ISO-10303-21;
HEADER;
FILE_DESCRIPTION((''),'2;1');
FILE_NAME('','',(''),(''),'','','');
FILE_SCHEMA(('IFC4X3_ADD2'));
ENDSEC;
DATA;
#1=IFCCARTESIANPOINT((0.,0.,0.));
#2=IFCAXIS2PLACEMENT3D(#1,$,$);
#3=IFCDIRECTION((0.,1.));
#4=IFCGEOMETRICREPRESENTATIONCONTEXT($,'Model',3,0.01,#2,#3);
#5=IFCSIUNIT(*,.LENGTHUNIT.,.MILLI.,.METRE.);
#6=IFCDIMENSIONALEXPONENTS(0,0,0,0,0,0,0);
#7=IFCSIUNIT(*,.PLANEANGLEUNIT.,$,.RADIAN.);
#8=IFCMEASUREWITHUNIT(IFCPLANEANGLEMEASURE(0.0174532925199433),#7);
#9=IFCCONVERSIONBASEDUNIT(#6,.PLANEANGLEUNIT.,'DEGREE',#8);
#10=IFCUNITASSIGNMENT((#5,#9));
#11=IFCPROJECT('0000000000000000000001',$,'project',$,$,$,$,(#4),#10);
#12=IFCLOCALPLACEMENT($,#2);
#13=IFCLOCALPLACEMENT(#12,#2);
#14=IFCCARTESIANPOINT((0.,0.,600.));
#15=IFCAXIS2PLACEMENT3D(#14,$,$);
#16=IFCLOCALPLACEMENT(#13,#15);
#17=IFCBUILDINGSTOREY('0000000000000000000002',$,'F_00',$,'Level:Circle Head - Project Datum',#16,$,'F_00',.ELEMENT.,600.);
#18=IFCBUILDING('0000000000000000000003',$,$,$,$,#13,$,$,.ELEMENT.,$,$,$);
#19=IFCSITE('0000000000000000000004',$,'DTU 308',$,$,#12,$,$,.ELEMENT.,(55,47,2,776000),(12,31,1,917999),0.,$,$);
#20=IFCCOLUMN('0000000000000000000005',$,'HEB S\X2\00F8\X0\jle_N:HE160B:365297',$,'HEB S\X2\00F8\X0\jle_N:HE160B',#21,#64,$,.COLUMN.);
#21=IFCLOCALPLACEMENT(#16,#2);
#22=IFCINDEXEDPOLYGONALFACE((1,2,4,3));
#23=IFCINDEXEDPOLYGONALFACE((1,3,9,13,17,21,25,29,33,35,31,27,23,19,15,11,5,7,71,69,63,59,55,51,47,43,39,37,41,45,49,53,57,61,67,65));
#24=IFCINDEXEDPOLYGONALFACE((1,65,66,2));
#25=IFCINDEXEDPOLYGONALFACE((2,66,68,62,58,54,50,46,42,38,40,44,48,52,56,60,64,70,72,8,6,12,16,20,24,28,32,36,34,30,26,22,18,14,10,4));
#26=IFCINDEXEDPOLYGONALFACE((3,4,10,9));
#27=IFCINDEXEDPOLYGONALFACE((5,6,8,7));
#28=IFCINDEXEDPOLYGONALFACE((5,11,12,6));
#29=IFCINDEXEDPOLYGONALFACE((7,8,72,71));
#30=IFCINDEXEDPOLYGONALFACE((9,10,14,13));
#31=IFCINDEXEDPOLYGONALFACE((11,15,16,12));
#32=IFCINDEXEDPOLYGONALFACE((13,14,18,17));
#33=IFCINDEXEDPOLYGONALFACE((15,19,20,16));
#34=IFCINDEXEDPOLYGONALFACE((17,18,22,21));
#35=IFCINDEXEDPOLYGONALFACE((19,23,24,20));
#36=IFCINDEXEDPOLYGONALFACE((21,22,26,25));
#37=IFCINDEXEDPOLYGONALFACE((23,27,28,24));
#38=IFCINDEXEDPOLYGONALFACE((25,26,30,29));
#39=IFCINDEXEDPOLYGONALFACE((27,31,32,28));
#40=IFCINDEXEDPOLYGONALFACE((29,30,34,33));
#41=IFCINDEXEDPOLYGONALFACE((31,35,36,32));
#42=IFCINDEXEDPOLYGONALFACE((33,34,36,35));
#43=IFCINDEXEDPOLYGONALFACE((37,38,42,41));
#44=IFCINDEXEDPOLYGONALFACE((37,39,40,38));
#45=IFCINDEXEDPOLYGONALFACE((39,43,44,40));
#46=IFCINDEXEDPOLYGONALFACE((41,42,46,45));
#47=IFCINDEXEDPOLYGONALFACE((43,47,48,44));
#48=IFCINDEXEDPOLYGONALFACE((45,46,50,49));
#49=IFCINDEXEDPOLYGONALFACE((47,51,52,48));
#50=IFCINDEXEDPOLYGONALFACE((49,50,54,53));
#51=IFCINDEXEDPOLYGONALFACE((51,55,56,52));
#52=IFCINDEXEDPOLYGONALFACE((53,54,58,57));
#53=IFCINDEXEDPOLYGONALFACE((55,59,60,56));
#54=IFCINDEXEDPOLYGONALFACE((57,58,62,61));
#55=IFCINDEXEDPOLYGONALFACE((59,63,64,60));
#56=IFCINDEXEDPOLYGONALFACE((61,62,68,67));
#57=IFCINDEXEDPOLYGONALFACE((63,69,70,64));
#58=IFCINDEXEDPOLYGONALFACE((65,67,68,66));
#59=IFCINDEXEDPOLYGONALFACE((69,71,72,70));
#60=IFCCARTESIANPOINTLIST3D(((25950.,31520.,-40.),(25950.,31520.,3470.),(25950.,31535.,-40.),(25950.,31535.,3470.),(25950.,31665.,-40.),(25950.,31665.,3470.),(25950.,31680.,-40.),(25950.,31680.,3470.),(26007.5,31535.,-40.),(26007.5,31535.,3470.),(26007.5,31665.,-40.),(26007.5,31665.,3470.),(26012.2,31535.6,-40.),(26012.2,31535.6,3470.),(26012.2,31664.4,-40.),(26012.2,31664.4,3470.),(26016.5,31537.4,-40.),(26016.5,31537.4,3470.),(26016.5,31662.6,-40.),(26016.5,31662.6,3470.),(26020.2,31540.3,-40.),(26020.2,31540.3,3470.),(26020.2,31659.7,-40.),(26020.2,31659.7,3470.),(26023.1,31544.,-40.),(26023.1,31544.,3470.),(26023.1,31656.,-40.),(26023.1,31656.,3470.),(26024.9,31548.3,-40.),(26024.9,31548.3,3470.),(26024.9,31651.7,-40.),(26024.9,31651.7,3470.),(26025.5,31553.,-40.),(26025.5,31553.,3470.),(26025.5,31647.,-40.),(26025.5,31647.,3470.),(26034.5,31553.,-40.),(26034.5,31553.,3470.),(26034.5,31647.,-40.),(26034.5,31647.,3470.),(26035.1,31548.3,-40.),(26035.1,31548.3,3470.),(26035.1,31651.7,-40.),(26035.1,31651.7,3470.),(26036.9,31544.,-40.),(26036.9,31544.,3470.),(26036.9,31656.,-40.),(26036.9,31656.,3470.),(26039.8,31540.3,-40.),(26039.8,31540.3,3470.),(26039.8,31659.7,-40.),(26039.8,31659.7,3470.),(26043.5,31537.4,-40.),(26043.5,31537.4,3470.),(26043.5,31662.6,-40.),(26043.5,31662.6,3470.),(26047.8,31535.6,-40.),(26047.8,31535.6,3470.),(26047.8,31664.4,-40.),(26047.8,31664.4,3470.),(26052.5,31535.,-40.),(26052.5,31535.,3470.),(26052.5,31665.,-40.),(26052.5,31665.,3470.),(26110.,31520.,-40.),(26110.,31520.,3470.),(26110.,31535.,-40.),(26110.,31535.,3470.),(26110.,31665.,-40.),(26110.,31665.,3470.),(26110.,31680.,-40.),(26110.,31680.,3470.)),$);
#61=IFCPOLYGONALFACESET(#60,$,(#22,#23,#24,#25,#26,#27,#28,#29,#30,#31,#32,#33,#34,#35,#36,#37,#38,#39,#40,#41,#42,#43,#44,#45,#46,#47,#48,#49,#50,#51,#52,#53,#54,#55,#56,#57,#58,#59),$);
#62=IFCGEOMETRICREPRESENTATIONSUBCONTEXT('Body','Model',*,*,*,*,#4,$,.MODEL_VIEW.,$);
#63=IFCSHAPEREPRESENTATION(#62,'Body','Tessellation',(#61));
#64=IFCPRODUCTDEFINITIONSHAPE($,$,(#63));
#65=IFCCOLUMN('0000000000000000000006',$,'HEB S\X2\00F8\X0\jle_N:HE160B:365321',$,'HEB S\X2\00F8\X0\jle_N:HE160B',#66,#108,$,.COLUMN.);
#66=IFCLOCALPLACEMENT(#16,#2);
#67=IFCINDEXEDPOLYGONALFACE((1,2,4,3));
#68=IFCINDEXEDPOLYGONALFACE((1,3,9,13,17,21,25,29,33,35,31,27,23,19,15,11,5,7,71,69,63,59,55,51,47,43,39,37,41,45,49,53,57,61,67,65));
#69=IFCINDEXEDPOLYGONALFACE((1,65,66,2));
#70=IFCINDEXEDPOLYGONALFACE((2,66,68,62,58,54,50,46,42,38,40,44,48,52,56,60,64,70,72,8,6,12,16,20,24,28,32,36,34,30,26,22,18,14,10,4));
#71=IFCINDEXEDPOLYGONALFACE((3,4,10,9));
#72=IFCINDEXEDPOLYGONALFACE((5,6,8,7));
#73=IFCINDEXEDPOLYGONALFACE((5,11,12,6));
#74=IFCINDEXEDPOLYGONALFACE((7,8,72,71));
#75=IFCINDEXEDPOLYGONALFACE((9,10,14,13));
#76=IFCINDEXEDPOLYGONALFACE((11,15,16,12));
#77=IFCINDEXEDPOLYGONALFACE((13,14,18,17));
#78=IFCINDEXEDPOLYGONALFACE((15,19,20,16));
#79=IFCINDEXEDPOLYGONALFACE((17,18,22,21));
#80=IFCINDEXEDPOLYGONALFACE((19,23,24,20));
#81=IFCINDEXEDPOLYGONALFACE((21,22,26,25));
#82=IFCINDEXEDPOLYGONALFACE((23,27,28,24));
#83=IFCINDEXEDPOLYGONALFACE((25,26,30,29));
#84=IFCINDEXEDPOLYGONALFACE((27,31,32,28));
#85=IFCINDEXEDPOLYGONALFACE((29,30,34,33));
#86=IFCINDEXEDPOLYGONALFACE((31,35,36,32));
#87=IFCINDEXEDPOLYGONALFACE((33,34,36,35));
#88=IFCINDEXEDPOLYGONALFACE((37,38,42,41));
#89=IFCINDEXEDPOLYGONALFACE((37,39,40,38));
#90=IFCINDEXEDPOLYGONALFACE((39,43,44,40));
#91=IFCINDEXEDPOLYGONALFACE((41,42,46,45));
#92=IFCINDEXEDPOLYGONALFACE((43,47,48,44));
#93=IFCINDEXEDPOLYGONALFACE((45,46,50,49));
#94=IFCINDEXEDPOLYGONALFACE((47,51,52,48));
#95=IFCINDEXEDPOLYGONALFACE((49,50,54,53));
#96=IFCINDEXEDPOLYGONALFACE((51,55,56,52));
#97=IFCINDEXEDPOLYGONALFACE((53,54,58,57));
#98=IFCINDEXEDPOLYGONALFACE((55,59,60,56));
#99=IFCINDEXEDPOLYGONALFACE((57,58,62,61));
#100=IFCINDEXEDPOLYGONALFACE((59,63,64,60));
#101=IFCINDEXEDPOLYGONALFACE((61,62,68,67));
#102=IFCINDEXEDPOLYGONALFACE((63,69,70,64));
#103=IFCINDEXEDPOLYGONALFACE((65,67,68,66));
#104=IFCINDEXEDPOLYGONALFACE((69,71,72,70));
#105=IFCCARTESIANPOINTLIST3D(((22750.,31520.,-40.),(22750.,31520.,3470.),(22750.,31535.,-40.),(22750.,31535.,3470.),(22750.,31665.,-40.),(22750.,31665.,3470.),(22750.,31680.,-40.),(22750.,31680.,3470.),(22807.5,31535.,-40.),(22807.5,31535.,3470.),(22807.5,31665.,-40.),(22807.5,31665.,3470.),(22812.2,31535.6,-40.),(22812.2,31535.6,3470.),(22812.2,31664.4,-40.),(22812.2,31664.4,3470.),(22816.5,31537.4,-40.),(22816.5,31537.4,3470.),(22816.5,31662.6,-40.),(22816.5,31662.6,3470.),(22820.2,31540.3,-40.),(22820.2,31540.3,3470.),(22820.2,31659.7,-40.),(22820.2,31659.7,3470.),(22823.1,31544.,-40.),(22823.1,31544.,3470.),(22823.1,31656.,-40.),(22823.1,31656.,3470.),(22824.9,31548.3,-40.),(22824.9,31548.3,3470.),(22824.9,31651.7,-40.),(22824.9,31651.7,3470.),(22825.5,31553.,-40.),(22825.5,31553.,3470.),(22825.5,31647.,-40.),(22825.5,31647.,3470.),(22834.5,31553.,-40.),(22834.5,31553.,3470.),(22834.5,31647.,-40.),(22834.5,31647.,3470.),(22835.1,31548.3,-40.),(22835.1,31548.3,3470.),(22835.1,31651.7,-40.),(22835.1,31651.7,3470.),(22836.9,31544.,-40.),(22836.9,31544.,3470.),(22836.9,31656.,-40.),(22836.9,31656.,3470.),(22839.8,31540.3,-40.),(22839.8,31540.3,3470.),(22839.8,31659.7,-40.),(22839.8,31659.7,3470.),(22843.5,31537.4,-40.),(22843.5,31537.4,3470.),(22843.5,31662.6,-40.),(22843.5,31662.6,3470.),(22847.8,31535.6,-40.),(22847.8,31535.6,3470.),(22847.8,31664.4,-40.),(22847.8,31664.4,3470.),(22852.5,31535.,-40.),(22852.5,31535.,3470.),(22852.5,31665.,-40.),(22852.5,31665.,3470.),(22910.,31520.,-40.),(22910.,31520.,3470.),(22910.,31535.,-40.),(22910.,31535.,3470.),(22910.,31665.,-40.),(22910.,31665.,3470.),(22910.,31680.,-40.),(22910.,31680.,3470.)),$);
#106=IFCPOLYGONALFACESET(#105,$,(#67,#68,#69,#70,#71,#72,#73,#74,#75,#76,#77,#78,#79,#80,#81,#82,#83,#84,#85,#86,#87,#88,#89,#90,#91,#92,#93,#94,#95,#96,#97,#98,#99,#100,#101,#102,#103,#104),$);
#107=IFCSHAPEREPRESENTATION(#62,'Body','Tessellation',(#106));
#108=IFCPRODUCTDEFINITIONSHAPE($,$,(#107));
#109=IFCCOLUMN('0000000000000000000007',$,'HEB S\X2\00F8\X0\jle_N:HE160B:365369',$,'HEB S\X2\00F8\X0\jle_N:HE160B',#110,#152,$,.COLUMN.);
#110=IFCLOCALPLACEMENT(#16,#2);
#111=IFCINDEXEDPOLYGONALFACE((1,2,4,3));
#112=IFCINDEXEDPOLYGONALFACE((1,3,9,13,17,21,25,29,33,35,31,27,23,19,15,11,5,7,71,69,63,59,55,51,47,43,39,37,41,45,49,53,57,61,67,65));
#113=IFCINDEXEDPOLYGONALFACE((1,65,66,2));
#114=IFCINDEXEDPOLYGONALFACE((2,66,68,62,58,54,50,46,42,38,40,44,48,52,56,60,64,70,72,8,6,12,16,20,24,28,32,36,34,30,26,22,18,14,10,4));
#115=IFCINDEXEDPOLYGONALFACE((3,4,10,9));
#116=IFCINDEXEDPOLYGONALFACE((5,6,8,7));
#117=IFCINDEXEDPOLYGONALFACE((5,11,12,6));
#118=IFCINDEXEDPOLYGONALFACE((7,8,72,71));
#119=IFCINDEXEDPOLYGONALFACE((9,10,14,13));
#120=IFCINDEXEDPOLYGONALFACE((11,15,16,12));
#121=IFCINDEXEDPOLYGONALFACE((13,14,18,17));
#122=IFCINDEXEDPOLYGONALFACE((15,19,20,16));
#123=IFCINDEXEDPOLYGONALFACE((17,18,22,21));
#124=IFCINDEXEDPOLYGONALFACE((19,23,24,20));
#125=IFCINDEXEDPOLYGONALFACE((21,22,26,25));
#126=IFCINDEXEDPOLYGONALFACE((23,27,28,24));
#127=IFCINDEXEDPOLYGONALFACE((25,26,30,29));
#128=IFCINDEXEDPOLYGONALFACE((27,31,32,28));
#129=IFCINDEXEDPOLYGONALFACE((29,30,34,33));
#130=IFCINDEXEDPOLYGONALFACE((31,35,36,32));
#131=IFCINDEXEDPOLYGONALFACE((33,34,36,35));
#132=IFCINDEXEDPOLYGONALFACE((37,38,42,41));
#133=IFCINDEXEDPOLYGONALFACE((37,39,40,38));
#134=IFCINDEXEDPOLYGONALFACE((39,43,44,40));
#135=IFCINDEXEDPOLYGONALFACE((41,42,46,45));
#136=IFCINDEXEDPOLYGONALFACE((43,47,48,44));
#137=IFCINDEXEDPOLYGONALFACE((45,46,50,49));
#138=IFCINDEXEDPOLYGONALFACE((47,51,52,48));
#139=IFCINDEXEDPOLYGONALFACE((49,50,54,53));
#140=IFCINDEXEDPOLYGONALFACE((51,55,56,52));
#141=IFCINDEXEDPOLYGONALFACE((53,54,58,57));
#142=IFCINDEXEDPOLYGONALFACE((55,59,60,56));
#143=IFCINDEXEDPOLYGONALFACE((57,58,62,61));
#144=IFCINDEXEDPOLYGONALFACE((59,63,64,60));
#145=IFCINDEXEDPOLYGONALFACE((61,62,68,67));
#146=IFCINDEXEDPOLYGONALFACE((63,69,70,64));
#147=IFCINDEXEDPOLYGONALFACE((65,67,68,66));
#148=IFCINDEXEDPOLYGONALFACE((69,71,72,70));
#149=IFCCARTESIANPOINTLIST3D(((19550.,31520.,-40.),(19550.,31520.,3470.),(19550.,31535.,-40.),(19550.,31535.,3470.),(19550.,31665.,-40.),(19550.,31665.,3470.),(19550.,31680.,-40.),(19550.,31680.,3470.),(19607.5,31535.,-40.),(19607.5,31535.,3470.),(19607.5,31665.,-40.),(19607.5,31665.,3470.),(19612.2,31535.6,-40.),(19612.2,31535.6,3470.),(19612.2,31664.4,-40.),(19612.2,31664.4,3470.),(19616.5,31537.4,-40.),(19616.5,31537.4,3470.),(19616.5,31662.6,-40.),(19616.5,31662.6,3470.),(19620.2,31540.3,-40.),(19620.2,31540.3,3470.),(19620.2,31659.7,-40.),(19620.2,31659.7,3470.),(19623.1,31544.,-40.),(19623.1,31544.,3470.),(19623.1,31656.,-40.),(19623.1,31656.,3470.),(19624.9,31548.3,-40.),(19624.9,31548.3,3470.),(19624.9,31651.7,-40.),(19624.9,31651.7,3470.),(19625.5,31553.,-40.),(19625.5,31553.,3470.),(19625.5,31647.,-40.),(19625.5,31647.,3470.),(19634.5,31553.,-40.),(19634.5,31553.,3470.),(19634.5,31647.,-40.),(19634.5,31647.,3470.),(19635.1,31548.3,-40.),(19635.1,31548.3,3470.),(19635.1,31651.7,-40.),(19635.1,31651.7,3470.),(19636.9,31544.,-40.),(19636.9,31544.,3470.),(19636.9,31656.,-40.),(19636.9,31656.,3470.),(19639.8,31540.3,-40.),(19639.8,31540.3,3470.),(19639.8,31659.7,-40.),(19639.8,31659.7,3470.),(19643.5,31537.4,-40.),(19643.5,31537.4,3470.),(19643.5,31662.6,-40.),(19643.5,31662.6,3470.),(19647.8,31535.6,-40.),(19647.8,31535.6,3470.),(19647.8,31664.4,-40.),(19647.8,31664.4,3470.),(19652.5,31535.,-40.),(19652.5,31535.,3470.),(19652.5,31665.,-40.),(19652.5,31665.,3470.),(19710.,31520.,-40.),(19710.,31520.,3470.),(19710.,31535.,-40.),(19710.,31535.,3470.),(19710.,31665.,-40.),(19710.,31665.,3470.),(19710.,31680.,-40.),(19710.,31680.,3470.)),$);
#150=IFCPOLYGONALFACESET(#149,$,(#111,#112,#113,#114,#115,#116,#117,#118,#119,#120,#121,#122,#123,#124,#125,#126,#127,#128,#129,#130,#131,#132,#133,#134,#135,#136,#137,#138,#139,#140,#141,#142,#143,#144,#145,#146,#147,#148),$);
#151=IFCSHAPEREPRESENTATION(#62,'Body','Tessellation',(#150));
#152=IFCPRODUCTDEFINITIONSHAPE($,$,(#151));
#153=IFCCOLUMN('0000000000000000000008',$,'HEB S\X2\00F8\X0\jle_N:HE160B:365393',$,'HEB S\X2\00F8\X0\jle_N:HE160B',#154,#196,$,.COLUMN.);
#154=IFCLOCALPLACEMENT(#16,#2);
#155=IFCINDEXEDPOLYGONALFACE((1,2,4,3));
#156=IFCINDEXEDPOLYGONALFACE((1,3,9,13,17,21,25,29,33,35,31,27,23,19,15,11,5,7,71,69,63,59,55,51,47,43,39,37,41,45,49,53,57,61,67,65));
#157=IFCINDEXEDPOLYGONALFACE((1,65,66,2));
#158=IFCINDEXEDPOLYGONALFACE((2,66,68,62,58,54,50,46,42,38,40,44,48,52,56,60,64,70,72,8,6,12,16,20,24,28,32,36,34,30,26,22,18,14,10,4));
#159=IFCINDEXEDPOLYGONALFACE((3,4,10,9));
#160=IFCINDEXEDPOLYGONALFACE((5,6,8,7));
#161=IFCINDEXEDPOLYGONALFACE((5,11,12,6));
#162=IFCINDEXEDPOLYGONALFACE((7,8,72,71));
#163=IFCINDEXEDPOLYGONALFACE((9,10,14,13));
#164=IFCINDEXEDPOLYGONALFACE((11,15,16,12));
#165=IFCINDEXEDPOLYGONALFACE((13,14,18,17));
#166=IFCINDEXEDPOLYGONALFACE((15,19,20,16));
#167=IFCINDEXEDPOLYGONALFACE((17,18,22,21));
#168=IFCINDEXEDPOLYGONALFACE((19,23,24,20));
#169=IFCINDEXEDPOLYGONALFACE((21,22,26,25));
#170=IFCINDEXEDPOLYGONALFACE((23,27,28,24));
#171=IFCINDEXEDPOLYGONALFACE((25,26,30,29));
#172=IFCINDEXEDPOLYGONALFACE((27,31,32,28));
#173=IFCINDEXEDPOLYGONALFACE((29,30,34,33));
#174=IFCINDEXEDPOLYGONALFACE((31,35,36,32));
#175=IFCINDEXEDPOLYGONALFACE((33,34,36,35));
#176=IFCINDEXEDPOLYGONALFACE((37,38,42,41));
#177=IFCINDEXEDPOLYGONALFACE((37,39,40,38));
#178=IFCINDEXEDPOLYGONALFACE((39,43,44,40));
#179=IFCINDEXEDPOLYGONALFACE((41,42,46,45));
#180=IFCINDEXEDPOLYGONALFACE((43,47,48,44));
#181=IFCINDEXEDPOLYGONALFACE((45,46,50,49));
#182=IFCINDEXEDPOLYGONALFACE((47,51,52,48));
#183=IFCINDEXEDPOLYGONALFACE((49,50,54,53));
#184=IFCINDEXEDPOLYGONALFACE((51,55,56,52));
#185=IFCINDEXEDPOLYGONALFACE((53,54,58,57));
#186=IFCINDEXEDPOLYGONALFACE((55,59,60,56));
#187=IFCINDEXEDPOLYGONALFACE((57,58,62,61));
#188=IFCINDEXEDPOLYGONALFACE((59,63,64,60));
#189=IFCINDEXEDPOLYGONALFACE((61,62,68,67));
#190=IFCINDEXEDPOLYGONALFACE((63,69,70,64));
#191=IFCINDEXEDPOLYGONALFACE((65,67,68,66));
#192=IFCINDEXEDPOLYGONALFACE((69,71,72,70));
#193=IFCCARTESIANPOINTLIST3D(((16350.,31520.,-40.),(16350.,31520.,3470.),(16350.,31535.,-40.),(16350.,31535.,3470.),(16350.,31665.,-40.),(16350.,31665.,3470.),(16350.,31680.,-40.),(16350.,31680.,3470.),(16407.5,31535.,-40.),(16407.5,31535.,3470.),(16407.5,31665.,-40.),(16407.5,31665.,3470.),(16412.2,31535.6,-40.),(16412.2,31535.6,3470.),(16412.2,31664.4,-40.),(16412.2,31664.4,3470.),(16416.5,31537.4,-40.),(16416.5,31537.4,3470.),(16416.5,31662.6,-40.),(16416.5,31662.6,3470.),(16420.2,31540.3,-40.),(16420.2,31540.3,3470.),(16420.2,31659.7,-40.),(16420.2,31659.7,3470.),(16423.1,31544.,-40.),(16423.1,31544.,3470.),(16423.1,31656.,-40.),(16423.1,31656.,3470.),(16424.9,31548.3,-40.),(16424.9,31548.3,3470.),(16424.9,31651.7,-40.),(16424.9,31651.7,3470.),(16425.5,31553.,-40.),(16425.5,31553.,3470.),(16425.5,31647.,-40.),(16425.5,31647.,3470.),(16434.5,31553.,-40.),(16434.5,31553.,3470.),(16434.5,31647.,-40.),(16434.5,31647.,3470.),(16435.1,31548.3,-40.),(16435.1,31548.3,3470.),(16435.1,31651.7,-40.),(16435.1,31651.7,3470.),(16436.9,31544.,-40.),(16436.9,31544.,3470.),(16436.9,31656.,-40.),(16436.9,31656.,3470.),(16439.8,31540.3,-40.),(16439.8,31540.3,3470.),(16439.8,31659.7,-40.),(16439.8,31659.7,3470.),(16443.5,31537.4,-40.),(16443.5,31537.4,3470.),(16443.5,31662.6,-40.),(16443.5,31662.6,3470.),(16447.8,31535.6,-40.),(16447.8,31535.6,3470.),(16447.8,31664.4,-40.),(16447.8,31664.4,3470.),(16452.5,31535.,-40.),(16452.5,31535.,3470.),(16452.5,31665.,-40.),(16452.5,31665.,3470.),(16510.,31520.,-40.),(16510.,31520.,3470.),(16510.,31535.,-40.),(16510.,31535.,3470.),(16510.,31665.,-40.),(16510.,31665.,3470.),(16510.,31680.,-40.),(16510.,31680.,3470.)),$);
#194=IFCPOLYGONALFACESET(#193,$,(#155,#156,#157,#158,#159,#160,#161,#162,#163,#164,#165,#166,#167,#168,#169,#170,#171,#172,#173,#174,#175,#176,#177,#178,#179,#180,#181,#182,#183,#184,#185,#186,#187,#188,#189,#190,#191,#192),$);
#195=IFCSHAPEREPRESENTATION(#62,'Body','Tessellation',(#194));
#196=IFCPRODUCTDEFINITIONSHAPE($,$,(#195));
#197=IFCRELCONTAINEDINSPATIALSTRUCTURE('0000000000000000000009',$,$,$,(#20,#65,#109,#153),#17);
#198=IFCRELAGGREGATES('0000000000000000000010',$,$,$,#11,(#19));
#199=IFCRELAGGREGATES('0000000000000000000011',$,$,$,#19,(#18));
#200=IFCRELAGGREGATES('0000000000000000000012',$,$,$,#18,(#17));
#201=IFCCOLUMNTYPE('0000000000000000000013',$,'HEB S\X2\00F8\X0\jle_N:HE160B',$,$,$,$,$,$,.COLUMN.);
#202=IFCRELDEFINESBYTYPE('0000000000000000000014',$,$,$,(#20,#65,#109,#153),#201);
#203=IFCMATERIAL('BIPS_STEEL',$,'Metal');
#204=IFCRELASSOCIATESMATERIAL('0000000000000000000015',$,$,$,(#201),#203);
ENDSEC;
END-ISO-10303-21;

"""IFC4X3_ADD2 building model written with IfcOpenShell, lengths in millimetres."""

from ifc_helpers import new_model, entity, si_unit, converted_unit, direction, frame, frame_2d, origin, place, context, subcontext, project, spatial, i_section, extrude, source, transform, mapped, material, material_profile, profile_set, type_object, type_shapes, element, save


model = new_model("IFC4X3_ADD2")

# Units and contexts
model_context = context("Model", 3, precision=0.01, world=origin(), true_north=direction((0.0, 1.0)))
body_context = subcontext(model_context, "Body", "Model", "MODEL_VIEW")
ifc_project = project(units=[si_unit("LENGTHUNIT", "METRE", prefix="MILLI"), converted_unit("PLANEANGLEUNIT", "DEGREE", entity("IfcPlaneAngleMeasure", 0.0174532925199433), si_unit("PLANEANGLEUNIT", "RADIAN"), dimensions=[0, 0, 0, 0, 0, 0, 0])], contexts=[model_context])

# Site, building, storey
site_placement = place(None, origin())
site = spatial("IfcSite", under=ifc_project, at=site_placement, Name="DTU 308", CompositionType="ELEMENT", RefLatitude=(55, 47, 2, 776000), RefLongitude=(12, 31, 1, 917999), RefElevation=0.0)
building_placement = place(site_placement, origin())
building = spatial("IfcBuilding", under=site, at=building_placement, CompositionType="ELEMENT")
storey_placement = place(building_placement, frame((0.0, 0.0, 600.0)))
storey = spatial("IfcBuildingStorey", under=building, at=storey_placement, Name="F_00", ObjectType="Level:Circle Head - Project Datum", LongName="F_00", CompositionType="ELEMENT", Elevation=600.0)

# Columns
ifc_material_1 = material(Name="BIPS_STEEL", Category="Metal")
ifc_material_profile_1 = material_profile(ifc_material_1, i_section(OverallWidth=160.0, OverallDepth=160.0, WebThickness=9.0, FlangeThickness=15.0, FilletRadius=18.0, at=frame_2d((0.0, 0.0), x_axis=(1.0, 0.0))), Name="HE160B")
ifc_profile_set_1 = profile_set([ifc_material_profile_1], Name="HE160B")
column_type = type_object("IfcColumnType", Name="HEB Søjle_N:HE160B", PredefinedType="COLUMN", material=ifc_profile_set_1)
shared_shape_1 = source(origin(), body_context, "Body", "SweptSolid", [
    extrude(i_section(OverallWidth=160.0, OverallDepth=160.0, WebThickness=9.0, FlangeThickness=15.0, FilletRadius=18.0, at=frame_2d((0.0, 0.0), x_axis=(1.0, 0.0))), frame((0.0, 0.0, 560.0), z_axis=(0.0, 0.0, 1.0), x_axis=(-1.0, 0.0, 0.0)), (0.0, 0.0, 1.0), 3510.0),
])
type_shapes(column_type, [shared_shape_1])
for number, where, name in (
    (1, (26030.0, 31600.0, -600.0), "HEB Søjle_N:HE160B:365297"),
    (2, (22830.0, 31600.0, -600.0), "HEB Søjle_N:HE160B:365321"),
    (3, (19630.0, 31600.0, -600.0), "HEB Søjle_N:HE160B:365369"),
    (4, (16430.0, 31600.0, -600.0), "HEB Søjle_N:HE160B:365393"),
):
    element("IfcColumn", number, at=place(storey_placement, frame(where)), inside=storey, type_object=column_type, Name=name, ObjectType="HEB Søjle_N:HE160B", PredefinedType="COLUMN", context=body_context, shape_type="MappedRepresentation", body=[
        mapped(shared_shape_1, transform((0.0, 0.0, 0.0), scale=1.0)),
    ])

save(model, "model.ifc")
